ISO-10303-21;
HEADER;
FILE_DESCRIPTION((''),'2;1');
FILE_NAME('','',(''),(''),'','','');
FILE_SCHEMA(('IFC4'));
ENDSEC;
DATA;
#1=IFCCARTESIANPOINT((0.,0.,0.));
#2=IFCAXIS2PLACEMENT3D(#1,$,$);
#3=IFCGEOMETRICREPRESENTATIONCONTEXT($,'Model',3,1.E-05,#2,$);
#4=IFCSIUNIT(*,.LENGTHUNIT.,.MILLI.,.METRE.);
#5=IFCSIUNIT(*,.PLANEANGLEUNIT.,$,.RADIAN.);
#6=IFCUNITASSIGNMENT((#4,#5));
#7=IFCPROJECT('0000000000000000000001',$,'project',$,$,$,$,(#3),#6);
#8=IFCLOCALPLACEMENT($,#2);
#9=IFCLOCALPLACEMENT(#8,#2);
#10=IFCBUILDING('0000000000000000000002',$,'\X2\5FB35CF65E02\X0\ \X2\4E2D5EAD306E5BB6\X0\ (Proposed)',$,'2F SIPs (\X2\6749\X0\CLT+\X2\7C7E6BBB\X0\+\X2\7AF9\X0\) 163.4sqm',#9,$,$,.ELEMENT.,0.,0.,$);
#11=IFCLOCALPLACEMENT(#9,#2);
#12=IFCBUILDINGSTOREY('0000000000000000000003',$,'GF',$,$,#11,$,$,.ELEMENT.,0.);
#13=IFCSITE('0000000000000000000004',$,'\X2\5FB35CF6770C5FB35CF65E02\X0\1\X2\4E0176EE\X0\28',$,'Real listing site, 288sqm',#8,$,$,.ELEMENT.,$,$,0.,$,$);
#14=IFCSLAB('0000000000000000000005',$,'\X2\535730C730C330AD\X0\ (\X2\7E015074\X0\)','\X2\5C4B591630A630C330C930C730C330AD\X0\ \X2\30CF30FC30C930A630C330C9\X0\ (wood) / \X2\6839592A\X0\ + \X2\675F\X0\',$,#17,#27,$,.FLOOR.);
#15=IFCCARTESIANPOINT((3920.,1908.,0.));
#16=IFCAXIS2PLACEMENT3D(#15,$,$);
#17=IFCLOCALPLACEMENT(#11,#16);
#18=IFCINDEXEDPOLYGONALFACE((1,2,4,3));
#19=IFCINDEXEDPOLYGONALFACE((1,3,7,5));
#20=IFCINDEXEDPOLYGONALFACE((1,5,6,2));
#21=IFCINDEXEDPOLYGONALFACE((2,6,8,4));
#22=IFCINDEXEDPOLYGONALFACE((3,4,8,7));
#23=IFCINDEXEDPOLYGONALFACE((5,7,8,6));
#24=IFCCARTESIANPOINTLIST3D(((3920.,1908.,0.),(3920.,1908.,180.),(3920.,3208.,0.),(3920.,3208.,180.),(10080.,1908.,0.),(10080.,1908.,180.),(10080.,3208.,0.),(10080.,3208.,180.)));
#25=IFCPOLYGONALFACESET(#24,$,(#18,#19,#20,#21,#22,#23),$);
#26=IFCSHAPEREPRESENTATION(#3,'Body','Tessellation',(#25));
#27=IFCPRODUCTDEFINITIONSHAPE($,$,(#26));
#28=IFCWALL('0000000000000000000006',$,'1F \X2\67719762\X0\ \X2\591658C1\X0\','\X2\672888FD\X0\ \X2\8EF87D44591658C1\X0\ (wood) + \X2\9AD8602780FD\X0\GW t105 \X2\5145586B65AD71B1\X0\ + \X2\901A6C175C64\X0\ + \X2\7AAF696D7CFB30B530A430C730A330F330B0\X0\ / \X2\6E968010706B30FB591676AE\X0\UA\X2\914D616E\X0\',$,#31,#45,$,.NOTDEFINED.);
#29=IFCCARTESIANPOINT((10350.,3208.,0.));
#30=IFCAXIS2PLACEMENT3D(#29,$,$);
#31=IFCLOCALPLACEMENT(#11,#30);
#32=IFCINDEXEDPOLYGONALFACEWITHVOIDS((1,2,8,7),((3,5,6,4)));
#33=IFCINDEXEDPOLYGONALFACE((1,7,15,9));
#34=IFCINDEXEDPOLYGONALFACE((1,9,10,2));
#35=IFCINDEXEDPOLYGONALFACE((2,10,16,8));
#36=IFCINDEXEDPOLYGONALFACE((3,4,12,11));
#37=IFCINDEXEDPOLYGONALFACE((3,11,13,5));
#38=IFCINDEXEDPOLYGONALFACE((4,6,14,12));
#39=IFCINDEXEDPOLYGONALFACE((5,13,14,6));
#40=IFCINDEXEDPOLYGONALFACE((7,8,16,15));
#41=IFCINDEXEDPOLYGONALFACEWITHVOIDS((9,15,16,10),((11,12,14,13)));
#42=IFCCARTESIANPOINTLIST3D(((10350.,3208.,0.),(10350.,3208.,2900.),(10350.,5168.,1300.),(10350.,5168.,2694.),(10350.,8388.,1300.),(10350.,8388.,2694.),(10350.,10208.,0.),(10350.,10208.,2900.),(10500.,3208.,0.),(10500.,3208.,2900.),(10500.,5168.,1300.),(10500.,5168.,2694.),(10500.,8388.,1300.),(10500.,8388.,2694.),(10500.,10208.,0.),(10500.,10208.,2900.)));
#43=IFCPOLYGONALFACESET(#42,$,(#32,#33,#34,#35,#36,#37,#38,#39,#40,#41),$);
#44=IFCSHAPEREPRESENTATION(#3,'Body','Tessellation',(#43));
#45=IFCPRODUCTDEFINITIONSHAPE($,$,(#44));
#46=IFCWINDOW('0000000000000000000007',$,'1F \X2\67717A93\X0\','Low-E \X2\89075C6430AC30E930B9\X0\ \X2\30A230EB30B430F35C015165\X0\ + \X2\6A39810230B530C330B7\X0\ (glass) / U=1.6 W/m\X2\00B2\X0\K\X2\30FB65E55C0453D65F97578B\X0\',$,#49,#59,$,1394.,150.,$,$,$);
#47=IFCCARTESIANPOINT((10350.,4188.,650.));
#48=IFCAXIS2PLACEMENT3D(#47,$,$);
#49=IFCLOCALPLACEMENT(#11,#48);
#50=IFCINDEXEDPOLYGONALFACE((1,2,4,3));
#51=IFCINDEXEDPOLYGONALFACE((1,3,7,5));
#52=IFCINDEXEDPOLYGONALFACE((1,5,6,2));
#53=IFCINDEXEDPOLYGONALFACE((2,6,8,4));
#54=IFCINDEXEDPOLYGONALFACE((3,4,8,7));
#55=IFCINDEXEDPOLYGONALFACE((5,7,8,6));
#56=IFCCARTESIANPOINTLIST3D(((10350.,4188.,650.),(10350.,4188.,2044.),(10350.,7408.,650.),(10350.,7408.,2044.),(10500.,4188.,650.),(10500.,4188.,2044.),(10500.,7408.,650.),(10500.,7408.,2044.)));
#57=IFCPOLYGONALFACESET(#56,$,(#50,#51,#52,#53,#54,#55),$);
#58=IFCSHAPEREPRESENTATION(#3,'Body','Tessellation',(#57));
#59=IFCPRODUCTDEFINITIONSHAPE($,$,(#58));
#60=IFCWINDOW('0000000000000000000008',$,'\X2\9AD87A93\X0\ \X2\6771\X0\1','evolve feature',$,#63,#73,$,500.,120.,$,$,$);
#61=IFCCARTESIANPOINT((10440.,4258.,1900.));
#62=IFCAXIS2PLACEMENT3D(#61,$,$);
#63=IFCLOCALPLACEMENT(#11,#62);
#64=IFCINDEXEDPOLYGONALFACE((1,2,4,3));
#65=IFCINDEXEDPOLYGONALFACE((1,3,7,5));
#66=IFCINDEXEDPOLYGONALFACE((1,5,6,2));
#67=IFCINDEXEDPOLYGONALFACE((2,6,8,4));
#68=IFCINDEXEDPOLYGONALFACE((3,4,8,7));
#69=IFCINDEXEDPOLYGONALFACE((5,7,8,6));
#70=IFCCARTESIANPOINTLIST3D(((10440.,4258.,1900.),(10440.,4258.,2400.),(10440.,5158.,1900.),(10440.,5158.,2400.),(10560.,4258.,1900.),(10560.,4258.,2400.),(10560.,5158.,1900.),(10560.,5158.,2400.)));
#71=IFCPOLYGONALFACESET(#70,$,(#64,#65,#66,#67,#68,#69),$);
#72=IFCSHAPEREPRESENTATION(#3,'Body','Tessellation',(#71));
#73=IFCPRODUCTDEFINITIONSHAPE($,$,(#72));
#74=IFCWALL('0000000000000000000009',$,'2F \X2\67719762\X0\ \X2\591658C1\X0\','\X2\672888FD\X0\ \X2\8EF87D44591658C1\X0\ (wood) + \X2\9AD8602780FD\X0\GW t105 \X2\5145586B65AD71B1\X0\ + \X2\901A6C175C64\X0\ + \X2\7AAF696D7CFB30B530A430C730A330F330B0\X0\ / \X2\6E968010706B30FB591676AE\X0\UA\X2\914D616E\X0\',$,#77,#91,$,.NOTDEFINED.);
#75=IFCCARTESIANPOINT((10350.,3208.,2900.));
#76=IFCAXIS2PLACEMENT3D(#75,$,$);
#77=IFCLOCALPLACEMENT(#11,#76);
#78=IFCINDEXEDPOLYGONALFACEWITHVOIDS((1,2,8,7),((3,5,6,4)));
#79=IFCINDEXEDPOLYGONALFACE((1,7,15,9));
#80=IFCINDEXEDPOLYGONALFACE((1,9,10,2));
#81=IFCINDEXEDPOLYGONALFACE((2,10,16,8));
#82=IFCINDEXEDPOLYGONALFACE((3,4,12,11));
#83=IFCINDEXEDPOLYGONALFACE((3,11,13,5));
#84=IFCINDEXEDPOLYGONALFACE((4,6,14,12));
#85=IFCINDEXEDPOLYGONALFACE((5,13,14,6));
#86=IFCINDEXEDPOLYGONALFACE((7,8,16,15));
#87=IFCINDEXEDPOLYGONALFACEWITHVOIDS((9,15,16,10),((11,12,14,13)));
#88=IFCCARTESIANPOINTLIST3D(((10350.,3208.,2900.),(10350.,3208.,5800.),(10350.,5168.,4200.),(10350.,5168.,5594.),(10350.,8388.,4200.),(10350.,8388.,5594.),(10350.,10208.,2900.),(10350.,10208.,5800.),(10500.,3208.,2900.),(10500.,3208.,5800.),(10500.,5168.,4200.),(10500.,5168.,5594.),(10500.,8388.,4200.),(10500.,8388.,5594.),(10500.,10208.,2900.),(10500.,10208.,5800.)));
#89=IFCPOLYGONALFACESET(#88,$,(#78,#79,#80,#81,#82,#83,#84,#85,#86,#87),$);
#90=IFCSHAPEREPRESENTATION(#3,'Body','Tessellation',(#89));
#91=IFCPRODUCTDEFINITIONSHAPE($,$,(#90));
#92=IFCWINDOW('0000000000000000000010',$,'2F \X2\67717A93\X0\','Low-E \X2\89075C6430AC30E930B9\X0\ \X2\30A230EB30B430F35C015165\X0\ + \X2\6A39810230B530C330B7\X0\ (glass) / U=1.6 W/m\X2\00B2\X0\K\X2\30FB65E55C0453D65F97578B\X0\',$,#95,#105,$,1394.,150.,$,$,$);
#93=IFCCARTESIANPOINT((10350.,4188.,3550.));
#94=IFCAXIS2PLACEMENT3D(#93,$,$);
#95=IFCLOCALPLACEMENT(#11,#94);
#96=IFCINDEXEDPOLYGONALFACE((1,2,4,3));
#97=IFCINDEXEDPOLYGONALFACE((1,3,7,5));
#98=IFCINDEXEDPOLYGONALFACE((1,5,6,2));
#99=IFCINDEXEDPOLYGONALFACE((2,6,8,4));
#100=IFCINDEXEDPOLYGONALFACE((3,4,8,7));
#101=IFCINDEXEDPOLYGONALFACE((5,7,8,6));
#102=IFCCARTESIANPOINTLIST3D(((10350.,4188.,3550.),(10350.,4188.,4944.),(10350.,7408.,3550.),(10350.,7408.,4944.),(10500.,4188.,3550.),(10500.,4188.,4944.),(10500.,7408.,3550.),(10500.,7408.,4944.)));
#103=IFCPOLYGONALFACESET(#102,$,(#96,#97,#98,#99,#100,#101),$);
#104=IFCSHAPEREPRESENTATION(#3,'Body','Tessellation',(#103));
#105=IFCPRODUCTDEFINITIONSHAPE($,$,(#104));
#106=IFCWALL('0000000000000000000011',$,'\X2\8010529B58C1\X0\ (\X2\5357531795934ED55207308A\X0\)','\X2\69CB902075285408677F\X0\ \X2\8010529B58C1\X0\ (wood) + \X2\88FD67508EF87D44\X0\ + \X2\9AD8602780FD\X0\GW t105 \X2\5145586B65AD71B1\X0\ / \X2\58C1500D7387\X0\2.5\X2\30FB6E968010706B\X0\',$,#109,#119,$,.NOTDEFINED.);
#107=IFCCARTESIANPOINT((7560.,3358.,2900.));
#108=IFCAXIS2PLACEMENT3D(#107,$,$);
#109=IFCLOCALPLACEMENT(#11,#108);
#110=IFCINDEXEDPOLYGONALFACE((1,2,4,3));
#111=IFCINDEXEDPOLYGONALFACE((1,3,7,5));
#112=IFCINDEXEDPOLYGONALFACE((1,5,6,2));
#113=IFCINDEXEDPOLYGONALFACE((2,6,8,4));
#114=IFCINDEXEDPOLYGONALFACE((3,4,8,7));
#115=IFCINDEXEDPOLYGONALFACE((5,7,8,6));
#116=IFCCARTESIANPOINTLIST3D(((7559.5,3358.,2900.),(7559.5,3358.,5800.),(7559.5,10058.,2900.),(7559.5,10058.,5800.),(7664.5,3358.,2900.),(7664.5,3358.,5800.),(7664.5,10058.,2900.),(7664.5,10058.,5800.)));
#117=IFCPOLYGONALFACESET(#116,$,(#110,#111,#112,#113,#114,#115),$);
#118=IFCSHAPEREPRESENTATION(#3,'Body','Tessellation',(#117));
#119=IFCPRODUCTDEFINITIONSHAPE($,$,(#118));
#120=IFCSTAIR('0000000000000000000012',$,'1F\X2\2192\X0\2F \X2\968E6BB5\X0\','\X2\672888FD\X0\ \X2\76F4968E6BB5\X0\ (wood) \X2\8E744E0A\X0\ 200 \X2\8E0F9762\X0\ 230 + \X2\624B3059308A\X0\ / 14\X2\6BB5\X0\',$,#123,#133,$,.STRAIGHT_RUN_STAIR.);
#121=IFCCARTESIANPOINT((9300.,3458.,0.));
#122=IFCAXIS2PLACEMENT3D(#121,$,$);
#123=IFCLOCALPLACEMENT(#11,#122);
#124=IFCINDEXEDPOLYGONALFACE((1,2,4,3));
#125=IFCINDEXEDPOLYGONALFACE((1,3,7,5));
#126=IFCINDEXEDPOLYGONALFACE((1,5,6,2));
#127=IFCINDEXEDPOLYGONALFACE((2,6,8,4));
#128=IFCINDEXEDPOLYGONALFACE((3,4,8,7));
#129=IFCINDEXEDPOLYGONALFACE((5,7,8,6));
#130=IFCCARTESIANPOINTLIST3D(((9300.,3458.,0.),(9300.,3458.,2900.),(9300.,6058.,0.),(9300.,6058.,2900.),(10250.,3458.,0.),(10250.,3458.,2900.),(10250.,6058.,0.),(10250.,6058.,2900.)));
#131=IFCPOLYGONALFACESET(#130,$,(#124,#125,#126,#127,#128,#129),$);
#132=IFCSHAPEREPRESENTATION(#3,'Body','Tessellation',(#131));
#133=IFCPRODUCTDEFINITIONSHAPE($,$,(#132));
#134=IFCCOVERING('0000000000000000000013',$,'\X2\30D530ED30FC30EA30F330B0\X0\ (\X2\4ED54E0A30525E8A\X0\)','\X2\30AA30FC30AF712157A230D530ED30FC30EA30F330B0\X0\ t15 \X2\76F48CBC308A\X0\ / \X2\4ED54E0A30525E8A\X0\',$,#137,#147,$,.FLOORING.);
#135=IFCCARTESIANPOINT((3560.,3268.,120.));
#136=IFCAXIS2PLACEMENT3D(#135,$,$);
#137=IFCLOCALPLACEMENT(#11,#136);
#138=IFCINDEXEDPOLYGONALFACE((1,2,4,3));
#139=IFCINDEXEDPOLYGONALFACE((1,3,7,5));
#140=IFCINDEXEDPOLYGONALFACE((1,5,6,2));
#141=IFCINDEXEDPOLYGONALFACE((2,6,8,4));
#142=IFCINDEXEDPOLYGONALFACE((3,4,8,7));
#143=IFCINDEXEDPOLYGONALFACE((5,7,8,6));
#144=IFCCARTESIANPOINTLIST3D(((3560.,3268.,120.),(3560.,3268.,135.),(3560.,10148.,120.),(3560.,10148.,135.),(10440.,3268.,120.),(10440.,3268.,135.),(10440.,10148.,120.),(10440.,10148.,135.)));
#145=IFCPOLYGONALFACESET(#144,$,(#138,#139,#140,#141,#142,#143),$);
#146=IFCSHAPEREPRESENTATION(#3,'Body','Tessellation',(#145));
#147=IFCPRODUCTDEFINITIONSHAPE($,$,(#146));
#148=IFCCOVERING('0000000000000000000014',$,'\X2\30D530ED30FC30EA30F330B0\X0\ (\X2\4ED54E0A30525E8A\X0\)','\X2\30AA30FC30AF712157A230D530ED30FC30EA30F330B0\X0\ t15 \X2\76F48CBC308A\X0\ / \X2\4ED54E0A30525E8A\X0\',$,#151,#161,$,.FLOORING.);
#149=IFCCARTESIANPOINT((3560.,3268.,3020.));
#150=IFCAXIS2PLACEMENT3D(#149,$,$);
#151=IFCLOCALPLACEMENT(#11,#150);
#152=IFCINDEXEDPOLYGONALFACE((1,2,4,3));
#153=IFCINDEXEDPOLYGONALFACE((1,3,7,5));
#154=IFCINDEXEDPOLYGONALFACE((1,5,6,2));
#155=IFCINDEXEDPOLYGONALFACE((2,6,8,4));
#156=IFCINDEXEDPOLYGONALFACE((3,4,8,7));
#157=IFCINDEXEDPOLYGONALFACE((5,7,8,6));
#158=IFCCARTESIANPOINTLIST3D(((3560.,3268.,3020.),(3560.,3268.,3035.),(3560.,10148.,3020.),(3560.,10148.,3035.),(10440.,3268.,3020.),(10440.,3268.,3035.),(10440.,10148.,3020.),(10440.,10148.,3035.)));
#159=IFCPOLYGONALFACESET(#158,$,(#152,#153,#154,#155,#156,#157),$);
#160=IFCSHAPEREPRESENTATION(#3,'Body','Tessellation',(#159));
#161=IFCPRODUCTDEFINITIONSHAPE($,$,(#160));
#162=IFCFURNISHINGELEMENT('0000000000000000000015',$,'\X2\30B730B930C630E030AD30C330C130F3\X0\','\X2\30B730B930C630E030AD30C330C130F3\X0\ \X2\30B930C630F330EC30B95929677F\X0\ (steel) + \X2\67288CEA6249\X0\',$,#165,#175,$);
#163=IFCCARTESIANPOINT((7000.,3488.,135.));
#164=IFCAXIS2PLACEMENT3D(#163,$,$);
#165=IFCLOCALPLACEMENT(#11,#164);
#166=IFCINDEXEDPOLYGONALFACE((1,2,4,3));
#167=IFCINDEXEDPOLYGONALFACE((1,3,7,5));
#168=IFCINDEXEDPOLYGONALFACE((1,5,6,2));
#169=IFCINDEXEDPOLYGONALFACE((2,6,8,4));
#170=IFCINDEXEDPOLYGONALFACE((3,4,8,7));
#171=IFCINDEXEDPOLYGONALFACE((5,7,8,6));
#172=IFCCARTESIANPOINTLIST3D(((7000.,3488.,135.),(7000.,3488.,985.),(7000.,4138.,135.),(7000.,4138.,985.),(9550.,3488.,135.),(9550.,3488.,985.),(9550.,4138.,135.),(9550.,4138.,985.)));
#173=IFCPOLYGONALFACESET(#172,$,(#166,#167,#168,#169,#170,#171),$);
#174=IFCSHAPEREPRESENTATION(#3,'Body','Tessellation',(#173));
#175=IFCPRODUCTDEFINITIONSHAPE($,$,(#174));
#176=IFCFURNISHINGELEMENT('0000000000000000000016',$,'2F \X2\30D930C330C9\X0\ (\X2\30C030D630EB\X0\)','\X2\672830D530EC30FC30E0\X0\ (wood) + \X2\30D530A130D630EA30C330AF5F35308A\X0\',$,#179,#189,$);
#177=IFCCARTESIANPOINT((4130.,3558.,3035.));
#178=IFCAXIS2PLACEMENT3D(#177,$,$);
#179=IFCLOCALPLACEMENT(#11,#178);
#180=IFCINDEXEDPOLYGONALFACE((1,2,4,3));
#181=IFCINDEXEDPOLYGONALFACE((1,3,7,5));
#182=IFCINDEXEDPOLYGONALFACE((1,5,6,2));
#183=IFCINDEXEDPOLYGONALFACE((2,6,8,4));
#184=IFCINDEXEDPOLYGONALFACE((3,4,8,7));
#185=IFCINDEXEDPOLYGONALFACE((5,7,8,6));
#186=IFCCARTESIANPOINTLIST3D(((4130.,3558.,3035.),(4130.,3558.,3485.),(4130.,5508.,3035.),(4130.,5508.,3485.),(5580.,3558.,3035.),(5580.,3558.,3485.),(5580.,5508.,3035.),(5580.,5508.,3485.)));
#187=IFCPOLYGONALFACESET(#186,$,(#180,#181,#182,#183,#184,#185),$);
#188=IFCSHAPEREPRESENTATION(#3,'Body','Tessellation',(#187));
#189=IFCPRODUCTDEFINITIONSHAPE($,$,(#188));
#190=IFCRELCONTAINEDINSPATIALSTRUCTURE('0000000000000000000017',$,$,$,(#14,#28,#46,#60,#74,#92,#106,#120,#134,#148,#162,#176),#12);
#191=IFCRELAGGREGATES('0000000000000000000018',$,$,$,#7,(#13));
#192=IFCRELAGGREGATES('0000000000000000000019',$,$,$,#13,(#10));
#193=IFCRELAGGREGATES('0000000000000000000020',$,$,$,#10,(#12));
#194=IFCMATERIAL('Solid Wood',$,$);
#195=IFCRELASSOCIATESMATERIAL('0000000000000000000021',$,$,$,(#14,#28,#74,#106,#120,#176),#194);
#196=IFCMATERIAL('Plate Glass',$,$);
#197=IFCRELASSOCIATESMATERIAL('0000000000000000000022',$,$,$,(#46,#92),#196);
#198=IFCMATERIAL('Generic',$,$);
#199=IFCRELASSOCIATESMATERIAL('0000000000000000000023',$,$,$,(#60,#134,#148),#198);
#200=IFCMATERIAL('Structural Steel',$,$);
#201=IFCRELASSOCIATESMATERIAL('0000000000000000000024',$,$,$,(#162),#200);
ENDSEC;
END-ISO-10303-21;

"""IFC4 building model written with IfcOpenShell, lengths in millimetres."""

from ifc_helpers import new_model, si_unit, frame, frame_2d, origin, place, context, project, spatial, rectangle, extrude, material, element, fill, save


model = new_model("IFC4")

# Units and contexts
model_context = context("Model", 3, precision=1e-05, world=origin())
ifc_project = project(units=[si_unit("LENGTHUNIT", "METRE", prefix="MILLI"), si_unit("PLANEANGLEUNIT", "RADIAN")], contexts=[model_context])

# Site, building, storey
site_placement = place(None, origin())
site = spatial("IfcSite", under=ifc_project, at=site_placement, Name="徳島県徳島市1丁目28", ObjectType="Real listing site, 288sqm", CompositionType="ELEMENT", RefElevation=0.0)
building_placement = place(site_placement, origin())
building = spatial("IfcBuilding", under=site, at=building_placement, Name="徳島市 中庭の家 (Proposed)", ObjectType="2F SIPs (杉CLT+籾殻+竹) 163.4sqm", CompositionType="ELEMENT", ElevationOfRefHeight=0.0, ElevationOfTerrain=0.0)
storey_placement = place(building_placement, origin())
storey = spatial("IfcBuildingStorey", under=building, at=storey_placement, Name="GF", CompositionType="ELEMENT", Elevation=0.0)

# Slab
ifc_material_1 = material(Name="Solid Wood")
slab_placement = place(storey_placement, frame((3920.0, 1908.0, 0.0)))
element("IfcSlab", 1, at=slab_placement, inside=storey, material=ifc_material_1, Name="南デッキ (縁側)", Description="屋外ウッドデッキ ハードウッド (wood) / 根太 + 束", PredefinedType="FLOOR", context=model_context, shape_type="SweptSolid", body=[
    extrude(rectangle(XDim=6160.0, YDim=1300.0, at=frame_2d((3080.0, 650.0))), frame((3920.0, 1908.0, 0.0)), (0.0, 0.0, 1.0), 180.0),
])

# Wall, openings, windows
wall_1_placement = place(storey_placement, frame((10350.0, 3208.0, 0.0)))
wall_1 = element("IfcWall", 2, at=wall_1_placement, inside=storey, material=ifc_material_1, Name="1F 東面 外壁", Description="木製 軸組外壁 (wood) + 高性能GW t105 充填断熱 + 通気層 + 窯業系サイディング / 準耐火・外皮UA配慮", PredefinedType="NOTDEFINED", context=model_context, shape_type="SweptSolid", body=[
    extrude(rectangle(XDim=150.0, YDim=7000.0, at=frame_2d((75.0, 3500.0))), frame((10350.0, 3208.0, 0.0)), (0.0, 0.0, 1.0), 2900.0),
])
opening_1_placement = place(storey_placement, frame((10350.0, 4188.0, 650.0)))
opening_1 = element("IfcOpeningElement", 3, at=opening_1_placement, cuts=wall_1, PredefinedType="NOTDEFINED", context=model_context, shape_type="SweptSolid", body=[
    extrude(rectangle(XDim=150.0, YDim=3220.0, at=frame_2d((75.0, 1610.0))), frame((10350.0, 4188.0, 650.0)), (0.0, 0.0, 1.0), 1394.0),
])
opening_2_placement = place(storey_placement, frame((10440.0, 4258.0, 1900.0)))
opening_2 = element("IfcOpeningElement", 4, at=opening_2_placement, cuts=wall_1, PredefinedType="NOTDEFINED", context=model_context, shape_type="SweptSolid", body=[
    extrude(rectangle(XDim=120.0, YDim=900.0, at=frame_2d((60.0, 450.0))), frame((10440.0, 4258.0, 1900.0)), (0.0, 0.0, 1.0), 500.0),
])
ifc_material_2 = material(Name="Plate Glass")
window_1_placement = place(storey_placement, frame((10350.0, 4188.0, 650.0)))
window_1 = element("IfcWindow", 5, at=window_1_placement, inside=storey, material=ifc_material_2, Name="1F 東窓", Description="Low-E 複層ガラス アルゴン封入 + 樹脂サッシ (glass) / U=1.6 W/m²K・日射取得型", OverallHeight=1394.0, OverallWidth=150.0, context=model_context, shape_type="SweptSolid", body=[
    extrude(rectangle(XDim=150.0, YDim=3220.0, at=frame_2d((75.0, 1610.0))), frame((10350.0, 4188.0, 650.0)), (0.0, 0.0, 1.0), 1394.0),
])
fill(opening_1, window_1)
ifc_material_3 = material(Name="Generic")
window_2_placement = place(storey_placement, frame((10440.0, 4258.0, 1900.0)))
window_2 = element("IfcWindow", 6, at=window_2_placement, inside=storey, material=ifc_material_3, Name="高窓 東1", Description="evolve feature", OverallHeight=500.0, OverallWidth=120.0, context=model_context, shape_type="SweptSolid", body=[
    extrude(rectangle(XDim=120.0, YDim=900.0, at=frame_2d((60.0, 450.0))), frame((10440.0, 4258.0, 1900.0)), (0.0, 0.0, 1.0), 500.0),
])
fill(opening_2, window_2)

# Wall, opening, window
wall_2_placement = place(storey_placement, frame((10350.0, 3208.0, 2900.0)))
wall_2 = element("IfcWall", 7, at=wall_2_placement, inside=storey, material=ifc_material_1, Name="2F 東面 外壁", Description="木製 軸組外壁 (wood) + 高性能GW t105 充填断熱 + 通気層 + 窯業系サイディング / 準耐火・外皮UA配慮", PredefinedType="NOTDEFINED", context=model_context, shape_type="SweptSolid", body=[
    extrude(rectangle(XDim=150.0, YDim=7000.0, at=frame_2d((75.0, 3500.0))), frame((10350.0, 3208.0, 2900.0)), (0.0, 0.0, 1.0), 2900.0),
])
opening_3_placement = place(storey_placement, frame((10350.0, 4188.0, 3550.0)))
opening_3 = element("IfcOpeningElement", 8, at=opening_3_placement, cuts=wall_2, PredefinedType="NOTDEFINED", context=model_context, shape_type="SweptSolid", body=[
    extrude(rectangle(XDim=150.0, YDim=3220.0, at=frame_2d((75.0, 1610.0))), frame((10350.0, 4188.0, 3550.0)), (0.0, 0.0, 1.0), 1394.0),
])
window_3_placement = place(storey_placement, frame((10350.0, 4188.0, 3550.0)))
window_3 = element("IfcWindow", 9, at=window_3_placement, inside=storey, material=ifc_material_2, Name="2F 東窓", Description="Low-E 複層ガラス アルゴン封入 + 樹脂サッシ (glass) / U=1.6 W/m²K・日射取得型", OverallHeight=1394.0, OverallWidth=150.0, context=model_context, shape_type="SweptSolid", body=[
    extrude(rectangle(XDim=150.0, YDim=3220.0, at=frame_2d((75.0, 1610.0))), frame((10350.0, 4188.0, 3550.0)), (0.0, 0.0, 1.0), 1394.0),
])
fill(opening_3, window_3)

# Wall
wall_3_placement = place(storey_placement, frame((7560.0, 3358.0, 2900.0)))
element("IfcWall", 10, at=wall_3_placement, inside=storey, material=ifc_material_1, Name="耐力壁 (南北間仕切り)", Description="構造用合板 耐力壁 (wood) + 製材軸組 + 高性能GW t105 充填断熱 / 壁倍率2.5・準耐火", PredefinedType="NOTDEFINED", context=model_context, shape_type="SweptSolid", body=[
    extrude(rectangle(XDim=105.0, YDim=6700.0, at=frame_2d((52.0, 3350.0))), frame((7560.0, 3358.0, 2900.0)), (0.0, 0.0, 1.0), 2900.0),
])

# Stair
stair_placement = place(storey_placement, frame((9300.0, 3458.0, 0.0)))
element("IfcStair", 11, at=stair_placement, inside=storey, material=ifc_material_1, Name="1F→2F 階段", Description="木製 直階段 (wood) 蹴上 200 踏面 230 + 手すり / 14段", PredefinedType="STRAIGHT_RUN_STAIR", context=model_context, shape_type="SweptSolid", body=[
    extrude(rectangle(XDim=950.0, YDim=2600.0, at=frame_2d((475.0, 1300.0))), frame((9300.0, 3458.0, 0.0)), (0.0, 0.0, 1.0), 2900.0),
])

# Coverings
covering_1_placement = place(storey_placement, frame((3560.0, 3268.0, 120.0)))
element("IfcCovering", 12, at=covering_1_placement, inside=storey, material=ifc_material_3, Name="フローリング (仕上げ床)", Description="オーク無垢フローリング t15 直貼り / 仕上げ床", PredefinedType="FLOORING", context=model_context, shape_type="SweptSolid", body=[
    extrude(rectangle(XDim=6880.0, YDim=6880.0, at=frame_2d((3440.0, 3440.0))), frame((3560.0, 3268.0, 120.0)), (0.0, 0.0, 1.0), 15.0),
])
covering_2_placement = place(storey_placement, frame((3560.0, 3268.0, 3020.0)))
element("IfcCovering", 13, at=covering_2_placement, inside=storey, material=ifc_material_3, Name="フローリング (仕上げ床)", Description="オーク無垢フローリング t15 直貼り / 仕上げ床", PredefinedType="FLOORING", context=model_context, shape_type="SweptSolid", body=[
    extrude(rectangle(XDim=6880.0, YDim=6880.0, at=frame_2d((3440.0, 3440.0))), frame((3560.0, 3268.0, 3020.0)), (0.0, 0.0, 1.0), 15.0),
])

# Furnishing elements
ifc_material_4 = material(Name="Structural Steel")
furnishing_1_placement = place(storey_placement, frame((7000.0, 3488.0, 135.0)))
element("IfcFurnishingElement", 14, at=furnishing_1_placement, inside=storey, material=ifc_material_4, Name="システムキッチン", Description="システムキッチン ステンレス天板 (steel) + 木質扉", context=model_context, shape_type="SweptSolid", body=[
    extrude(rectangle(XDim=2550.0, YDim=650.0, at=frame_2d((1275.0, 325.0))), frame((7000.0, 3488.0, 135.0)), (0.0, 0.0, 1.0), 850.0),
])
furnishing_2_placement = place(storey_placement, frame((4130.0, 3558.0, 3035.0)))
element("IfcFurnishingElement", 15, at=furnishing_2_placement, inside=storey, material=ifc_material_1, Name="2F ベッド (ダブル)", Description="木フレーム (wood) + ファブリック張り", context=model_context, shape_type="SweptSolid", body=[
    extrude(rectangle(XDim=1450.0, YDim=1950.0, at=frame_2d((725.0, 975.0))), frame((4130.0, 3558.0, 3035.0)), (0.0, 0.0, 1.0), 450.0),
])

save(model, "model.ifc")
